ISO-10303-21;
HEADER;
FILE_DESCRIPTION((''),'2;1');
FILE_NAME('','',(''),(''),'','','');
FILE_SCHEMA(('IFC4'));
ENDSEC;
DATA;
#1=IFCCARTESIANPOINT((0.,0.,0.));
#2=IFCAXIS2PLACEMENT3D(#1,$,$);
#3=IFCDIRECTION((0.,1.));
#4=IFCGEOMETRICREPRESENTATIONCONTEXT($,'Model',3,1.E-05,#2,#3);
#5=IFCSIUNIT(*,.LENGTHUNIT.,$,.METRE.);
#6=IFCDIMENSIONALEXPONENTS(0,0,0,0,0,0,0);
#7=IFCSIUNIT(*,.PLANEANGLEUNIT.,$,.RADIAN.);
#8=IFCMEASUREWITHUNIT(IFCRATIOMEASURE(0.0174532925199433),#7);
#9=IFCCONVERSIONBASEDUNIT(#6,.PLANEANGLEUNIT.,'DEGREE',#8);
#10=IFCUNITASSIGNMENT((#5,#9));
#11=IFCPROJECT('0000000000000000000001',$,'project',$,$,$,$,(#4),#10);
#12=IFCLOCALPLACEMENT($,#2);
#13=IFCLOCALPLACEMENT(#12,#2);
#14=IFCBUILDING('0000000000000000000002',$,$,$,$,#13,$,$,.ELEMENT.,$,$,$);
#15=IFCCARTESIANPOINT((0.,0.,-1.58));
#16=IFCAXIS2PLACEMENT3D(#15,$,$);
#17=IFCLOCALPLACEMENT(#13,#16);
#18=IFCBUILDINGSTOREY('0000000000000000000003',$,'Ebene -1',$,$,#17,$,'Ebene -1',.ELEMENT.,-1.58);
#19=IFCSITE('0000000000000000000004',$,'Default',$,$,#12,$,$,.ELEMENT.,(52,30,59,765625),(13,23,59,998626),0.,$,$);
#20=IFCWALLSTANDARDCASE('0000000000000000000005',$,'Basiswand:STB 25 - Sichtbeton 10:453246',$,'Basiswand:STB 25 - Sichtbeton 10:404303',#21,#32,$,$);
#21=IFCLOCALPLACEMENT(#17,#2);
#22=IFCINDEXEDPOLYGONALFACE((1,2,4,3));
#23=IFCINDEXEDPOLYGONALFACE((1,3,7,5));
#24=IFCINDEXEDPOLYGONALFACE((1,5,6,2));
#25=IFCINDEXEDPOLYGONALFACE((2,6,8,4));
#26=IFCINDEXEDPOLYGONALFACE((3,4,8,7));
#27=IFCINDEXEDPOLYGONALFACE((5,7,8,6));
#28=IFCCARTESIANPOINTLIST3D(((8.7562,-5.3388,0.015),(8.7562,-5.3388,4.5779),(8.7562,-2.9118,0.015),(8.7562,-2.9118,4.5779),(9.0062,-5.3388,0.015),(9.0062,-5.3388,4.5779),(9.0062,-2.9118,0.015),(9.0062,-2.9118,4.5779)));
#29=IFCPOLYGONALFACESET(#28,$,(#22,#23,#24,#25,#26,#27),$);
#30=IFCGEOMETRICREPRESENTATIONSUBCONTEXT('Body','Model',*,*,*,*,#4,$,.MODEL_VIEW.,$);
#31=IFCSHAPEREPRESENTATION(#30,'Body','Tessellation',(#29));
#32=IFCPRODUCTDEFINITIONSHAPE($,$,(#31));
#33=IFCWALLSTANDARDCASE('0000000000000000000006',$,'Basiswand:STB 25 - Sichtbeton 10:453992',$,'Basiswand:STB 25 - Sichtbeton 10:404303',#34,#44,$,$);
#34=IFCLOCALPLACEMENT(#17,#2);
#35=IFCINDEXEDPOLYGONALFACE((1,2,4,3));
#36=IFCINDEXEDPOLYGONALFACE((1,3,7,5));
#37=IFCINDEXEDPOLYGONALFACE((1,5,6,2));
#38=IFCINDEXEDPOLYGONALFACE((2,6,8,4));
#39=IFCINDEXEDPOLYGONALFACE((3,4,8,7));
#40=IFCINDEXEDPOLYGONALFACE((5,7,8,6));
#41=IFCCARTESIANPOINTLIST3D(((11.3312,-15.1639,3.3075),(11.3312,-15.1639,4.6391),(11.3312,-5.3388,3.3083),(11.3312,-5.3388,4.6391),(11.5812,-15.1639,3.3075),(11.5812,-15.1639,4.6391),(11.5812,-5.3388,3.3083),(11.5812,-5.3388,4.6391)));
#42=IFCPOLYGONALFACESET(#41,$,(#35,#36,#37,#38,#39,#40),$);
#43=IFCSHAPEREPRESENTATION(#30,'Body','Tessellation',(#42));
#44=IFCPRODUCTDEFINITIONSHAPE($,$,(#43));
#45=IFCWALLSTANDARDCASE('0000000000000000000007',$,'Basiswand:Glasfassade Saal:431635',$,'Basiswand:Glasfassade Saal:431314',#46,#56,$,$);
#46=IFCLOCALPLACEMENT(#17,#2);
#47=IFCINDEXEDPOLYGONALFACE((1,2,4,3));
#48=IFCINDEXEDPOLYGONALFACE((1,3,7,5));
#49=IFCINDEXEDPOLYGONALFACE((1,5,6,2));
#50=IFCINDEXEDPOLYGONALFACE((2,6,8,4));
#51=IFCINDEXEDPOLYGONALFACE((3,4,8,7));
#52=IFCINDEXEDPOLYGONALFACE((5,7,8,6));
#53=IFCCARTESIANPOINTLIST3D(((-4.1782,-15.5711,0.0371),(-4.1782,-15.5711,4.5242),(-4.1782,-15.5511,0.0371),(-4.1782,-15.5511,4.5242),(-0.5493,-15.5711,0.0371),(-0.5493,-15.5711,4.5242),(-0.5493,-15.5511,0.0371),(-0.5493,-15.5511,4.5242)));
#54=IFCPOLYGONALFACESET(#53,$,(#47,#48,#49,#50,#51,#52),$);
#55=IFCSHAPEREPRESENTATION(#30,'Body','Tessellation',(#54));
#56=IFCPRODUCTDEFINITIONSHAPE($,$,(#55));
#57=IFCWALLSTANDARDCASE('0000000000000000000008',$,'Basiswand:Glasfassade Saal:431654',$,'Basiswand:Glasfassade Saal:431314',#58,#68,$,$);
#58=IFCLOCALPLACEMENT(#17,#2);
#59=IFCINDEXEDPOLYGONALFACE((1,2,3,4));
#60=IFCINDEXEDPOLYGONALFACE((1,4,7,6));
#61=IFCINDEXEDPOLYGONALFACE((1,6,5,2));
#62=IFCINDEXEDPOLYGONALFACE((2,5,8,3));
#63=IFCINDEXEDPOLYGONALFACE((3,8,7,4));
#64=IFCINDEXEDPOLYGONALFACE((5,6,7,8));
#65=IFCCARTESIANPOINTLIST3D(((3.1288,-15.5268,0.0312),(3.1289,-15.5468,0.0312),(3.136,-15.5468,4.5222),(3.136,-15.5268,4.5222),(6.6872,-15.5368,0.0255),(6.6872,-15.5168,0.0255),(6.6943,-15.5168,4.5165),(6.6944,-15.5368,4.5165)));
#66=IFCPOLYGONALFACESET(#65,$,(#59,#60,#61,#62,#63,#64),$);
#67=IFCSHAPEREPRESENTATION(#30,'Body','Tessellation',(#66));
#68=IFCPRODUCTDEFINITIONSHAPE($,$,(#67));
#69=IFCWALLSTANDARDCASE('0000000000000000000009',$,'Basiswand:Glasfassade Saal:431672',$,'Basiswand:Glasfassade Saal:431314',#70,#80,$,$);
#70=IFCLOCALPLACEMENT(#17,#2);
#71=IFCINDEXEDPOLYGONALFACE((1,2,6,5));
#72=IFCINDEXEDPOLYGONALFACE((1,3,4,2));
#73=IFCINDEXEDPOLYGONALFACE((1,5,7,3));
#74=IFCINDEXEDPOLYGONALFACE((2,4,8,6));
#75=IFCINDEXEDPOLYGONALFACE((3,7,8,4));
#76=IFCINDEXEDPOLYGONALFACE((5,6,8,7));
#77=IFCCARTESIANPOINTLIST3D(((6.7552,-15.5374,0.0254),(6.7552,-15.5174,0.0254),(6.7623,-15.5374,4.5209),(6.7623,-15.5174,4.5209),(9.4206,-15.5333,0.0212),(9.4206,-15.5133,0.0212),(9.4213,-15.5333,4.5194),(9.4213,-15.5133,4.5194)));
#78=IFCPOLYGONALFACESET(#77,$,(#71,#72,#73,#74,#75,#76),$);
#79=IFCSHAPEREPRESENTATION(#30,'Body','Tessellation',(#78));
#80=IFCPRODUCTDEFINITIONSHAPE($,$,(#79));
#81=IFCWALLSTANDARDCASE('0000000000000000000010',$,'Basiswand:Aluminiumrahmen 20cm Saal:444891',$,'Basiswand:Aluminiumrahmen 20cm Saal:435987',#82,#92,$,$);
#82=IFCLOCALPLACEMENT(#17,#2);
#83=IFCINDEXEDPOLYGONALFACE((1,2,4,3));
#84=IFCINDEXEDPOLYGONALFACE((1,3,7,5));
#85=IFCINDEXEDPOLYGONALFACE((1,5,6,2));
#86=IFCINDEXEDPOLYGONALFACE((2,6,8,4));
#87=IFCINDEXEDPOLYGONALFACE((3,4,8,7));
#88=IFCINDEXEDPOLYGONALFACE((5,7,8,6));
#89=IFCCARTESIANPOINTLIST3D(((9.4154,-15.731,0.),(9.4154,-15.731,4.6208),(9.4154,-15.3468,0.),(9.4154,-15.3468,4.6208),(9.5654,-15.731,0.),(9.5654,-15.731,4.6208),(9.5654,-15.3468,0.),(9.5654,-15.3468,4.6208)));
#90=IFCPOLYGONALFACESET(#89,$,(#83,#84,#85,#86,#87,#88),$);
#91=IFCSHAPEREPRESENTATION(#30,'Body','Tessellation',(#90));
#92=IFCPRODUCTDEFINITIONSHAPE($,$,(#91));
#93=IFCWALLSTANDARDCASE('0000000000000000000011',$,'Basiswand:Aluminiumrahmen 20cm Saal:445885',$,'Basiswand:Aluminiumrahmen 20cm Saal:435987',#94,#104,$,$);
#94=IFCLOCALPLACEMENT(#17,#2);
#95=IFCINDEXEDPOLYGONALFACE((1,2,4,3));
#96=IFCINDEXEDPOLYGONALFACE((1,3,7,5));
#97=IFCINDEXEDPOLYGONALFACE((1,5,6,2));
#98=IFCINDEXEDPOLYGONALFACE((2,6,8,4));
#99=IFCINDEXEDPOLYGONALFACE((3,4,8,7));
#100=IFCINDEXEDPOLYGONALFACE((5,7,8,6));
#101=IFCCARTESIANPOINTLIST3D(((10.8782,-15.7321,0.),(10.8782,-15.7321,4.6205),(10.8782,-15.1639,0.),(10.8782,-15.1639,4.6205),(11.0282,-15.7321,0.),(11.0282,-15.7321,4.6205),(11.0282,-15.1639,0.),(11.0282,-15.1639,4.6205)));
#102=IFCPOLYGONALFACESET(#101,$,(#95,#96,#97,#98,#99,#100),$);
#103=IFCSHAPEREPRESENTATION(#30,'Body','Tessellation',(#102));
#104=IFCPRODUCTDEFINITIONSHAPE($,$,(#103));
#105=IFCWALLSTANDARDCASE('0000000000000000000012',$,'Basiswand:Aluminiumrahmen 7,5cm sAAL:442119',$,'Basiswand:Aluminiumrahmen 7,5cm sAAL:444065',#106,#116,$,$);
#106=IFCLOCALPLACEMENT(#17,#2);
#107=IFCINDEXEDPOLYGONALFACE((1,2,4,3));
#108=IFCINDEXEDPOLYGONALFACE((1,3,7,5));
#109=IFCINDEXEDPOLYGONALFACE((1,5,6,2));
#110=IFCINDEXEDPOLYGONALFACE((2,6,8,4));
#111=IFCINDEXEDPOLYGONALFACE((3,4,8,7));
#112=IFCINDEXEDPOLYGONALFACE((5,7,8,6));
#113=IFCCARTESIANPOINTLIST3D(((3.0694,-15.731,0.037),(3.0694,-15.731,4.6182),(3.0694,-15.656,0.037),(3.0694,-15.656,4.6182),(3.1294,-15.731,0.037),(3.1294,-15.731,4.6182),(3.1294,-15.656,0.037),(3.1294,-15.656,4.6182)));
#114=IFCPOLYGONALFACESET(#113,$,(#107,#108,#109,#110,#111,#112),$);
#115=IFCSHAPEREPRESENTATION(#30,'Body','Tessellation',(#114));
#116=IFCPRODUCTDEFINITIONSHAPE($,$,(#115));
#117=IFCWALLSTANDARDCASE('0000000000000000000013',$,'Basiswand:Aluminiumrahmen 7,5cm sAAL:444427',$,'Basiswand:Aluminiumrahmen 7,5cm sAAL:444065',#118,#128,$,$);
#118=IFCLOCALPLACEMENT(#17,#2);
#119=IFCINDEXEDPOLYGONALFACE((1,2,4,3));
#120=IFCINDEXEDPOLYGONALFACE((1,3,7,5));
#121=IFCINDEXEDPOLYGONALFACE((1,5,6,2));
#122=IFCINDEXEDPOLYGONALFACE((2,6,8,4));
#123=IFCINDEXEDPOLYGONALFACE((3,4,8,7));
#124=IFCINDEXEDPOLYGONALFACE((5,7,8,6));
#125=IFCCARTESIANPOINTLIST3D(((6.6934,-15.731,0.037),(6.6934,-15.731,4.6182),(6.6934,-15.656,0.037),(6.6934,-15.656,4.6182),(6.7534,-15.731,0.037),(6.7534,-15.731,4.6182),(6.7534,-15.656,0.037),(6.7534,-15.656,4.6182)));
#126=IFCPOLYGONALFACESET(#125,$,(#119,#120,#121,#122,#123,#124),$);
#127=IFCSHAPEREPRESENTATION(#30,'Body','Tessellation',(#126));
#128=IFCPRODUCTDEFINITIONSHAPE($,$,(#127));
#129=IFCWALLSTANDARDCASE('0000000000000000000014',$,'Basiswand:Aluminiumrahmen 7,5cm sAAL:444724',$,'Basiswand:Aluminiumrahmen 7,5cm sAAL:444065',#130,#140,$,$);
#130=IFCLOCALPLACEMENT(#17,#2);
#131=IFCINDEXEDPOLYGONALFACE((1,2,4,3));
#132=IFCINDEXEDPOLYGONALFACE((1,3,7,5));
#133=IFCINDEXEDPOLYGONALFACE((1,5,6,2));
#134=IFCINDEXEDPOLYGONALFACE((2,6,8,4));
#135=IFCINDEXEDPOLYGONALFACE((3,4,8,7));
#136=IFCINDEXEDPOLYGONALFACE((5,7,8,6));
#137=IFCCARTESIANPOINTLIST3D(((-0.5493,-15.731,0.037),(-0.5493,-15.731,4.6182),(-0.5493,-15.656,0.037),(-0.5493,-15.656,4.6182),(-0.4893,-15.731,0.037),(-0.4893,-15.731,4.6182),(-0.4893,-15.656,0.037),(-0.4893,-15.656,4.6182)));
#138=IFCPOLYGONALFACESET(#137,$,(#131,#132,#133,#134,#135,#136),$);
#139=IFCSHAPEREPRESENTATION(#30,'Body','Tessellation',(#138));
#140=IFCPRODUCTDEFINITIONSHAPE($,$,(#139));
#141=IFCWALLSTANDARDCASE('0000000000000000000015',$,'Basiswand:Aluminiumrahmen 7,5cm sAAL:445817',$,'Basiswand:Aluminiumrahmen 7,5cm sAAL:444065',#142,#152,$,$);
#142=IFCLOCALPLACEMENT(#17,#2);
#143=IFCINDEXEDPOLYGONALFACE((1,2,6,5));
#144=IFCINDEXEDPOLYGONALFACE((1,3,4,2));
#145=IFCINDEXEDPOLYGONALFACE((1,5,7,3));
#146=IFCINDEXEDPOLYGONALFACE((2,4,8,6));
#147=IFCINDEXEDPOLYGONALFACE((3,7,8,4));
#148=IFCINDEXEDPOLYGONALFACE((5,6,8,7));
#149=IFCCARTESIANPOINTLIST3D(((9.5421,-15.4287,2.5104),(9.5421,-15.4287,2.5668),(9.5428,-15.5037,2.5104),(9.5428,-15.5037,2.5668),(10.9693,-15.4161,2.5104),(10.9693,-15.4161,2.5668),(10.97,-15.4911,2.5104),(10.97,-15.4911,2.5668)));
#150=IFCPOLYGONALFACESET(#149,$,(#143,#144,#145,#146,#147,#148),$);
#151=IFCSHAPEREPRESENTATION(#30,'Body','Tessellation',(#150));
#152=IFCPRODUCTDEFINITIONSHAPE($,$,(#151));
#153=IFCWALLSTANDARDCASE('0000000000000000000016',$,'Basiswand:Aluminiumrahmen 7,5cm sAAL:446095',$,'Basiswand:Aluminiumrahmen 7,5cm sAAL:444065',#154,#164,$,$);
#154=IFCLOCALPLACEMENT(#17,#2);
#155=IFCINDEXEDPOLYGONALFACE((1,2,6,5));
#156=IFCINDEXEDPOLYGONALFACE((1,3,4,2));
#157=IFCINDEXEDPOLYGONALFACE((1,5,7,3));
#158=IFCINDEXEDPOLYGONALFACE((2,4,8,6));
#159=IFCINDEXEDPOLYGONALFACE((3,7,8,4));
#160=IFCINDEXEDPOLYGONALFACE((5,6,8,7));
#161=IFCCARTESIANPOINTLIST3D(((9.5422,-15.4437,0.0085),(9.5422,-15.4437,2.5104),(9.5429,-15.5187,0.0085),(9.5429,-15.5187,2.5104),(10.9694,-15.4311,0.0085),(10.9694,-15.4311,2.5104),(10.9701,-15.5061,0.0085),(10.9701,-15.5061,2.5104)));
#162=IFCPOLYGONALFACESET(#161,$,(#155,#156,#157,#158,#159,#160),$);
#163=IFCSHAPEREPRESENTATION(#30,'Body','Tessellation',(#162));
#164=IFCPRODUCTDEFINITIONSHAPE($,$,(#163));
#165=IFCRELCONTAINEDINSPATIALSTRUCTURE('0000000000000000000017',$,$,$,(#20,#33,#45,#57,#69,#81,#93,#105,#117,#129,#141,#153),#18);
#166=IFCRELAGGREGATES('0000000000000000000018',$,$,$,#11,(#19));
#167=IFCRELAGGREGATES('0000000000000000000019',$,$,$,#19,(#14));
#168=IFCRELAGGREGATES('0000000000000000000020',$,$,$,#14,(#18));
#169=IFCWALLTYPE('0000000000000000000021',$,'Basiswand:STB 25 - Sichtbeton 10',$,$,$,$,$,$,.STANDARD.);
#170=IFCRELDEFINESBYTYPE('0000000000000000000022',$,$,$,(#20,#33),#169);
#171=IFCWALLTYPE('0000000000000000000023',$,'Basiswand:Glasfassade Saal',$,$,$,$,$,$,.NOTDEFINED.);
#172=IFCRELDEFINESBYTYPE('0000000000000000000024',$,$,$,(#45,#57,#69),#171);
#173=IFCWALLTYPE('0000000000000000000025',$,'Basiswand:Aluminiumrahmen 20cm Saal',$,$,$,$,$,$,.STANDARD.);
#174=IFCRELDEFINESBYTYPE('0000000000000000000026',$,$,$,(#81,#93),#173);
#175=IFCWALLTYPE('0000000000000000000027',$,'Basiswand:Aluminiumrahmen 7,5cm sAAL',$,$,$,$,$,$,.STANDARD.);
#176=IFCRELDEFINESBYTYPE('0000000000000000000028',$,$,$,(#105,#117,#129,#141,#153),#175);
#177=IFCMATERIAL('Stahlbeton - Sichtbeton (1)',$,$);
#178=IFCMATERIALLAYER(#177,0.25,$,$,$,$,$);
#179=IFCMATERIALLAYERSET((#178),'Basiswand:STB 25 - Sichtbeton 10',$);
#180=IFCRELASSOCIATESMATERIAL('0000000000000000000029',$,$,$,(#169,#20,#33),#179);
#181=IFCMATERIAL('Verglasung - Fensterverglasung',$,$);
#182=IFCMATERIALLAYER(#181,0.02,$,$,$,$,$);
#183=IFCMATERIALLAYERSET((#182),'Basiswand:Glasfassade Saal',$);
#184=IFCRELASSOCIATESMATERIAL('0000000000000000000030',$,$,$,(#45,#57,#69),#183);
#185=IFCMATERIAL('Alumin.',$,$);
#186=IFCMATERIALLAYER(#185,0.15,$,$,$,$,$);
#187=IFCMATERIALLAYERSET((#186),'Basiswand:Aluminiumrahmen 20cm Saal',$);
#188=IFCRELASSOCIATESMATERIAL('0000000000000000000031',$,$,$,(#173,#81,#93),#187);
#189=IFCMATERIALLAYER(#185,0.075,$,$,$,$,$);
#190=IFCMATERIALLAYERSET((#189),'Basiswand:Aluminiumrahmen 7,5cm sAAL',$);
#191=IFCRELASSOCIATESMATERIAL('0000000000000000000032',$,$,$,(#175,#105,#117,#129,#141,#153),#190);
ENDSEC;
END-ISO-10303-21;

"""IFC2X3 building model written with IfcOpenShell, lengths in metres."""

from ifc_helpers import new_model, entity, si_unit, converted_unit, direction, frame, frame_2d, origin, place, context, subcontext, project, spatial, rectangle, extrude, clip, halfspace, material, layer, layer_set, layer_usage, type_object, element, save


model = new_model("IFC2X3")

# Units and contexts
model_context = context("Model", 3, precision=1e-05, world=origin(), true_north=direction((0.0, 1.0)))
body_context = subcontext(model_context, "Body", "Model", "MODEL_VIEW")
ifc_project = project(units=[si_unit("LENGTHUNIT", "METRE"), converted_unit("PLANEANGLEUNIT", "DEGREE", entity("IfcRatioMeasure", 0.0174532925199433), si_unit("PLANEANGLEUNIT", "RADIAN"), dimensions=[0, 0, 0, 0, 0, 0, 0])], contexts=[model_context])

# Site, building, storey
site_placement = place(None, origin())
site = spatial("IfcSite", under=ifc_project, at=site_placement, Name="Default", CompositionType="ELEMENT", RefLatitude=(52, 30, 59, 765625), RefLongitude=(13, 23, 59, 998626), RefElevation=0.0)
building_placement = place(site_placement, origin())
building = spatial("IfcBuilding", under=site, at=building_placement, CompositionType="ELEMENT")
storey_placement = place(building_placement, frame((0.0, 0.0, -1.58)))
storey = spatial("IfcBuildingStorey", under=building, at=storey_placement, Name="Ebene -1", LongName="Ebene -1", CompositionType="ELEMENT", Elevation=-1.58)

# Shared definitions
ifc_material_1 = material(Name="Stahlbeton - Sichtbeton (1)")

# Walls
ifc_layer_1 = layer(ifc_material_1, 0.25)
ifc_layer_set_1 = layer_set([ifc_layer_1], Name="Basiswand:STB 25 - Sichtbeton 10")
ifc_layer_usage_1 = layer_usage(ifc_layer_set_1, "AXIS2", "NEGATIVE", 0.125)
wall_type_1 = type_object("IfcWallType", Name="Basiswand:STB 25 - Sichtbeton 10", PredefinedType="STANDARD", material=ifc_layer_set_1)
wall_1_placement = place(storey_placement, frame((8.8812, -5.3388, 0.015), z_axis=(0.0, 0.0, 1.0), x_axis=(0.0, 1.0, 0.0)))
element("IfcWallStandardCase", 1, at=wall_1_placement, inside=storey, type_object=wall_type_1, material=ifc_layer_usage_1, Name="Basiswand:STB 25 - Sichtbeton 10:453246", ObjectType="Basiswand:STB 25 - Sichtbeton 10:404303", context=body_context, shape_type="SweptSolid", body=[
    extrude(rectangle(XDim=2.427, YDim=0.25, at=frame_2d((1.2135, 0.0), x_axis=(-1.0, 0.0))), origin(), (0.0, 0.0, 1.0), 4.5629),
])
ifc_layer_usage_2 = layer_usage(ifc_layer_set_1, "AXIS2", "POSITIVE", -0.125)
wall_2_placement = place(storey_placement, frame((11.4562, -15.1639, 3.3075), z_axis=(0.0, 0.0, 1.0), x_axis=(0.0, 1.0, 0.0)))
element("IfcWallStandardCase", 2, at=wall_2_placement, inside=storey, type_object=wall_type_1, material=ifc_layer_usage_2, Name="Basiswand:STB 25 - Sichtbeton 10:453992", ObjectType="Basiswand:STB 25 - Sichtbeton 10:404303", context=body_context, shape_type="Clipping", body=[
    clip(extrude(rectangle(XDim=9.8251, YDim=0.25, at=frame_2d((4.9126, 0.0), x_axis=(-1.0, 0.0))), origin(), (0.0, 0.0, 1.0), 1.3316), halfspace(frame((9.8251, -0.125, 0.0008), z_axis=(0.000083, 0.0, -1.0), x_axis=(0.0, 1.0, 0.0)), False)),
])
ifc_material_2 = material(Name="Verglasung - Fensterverglasung")
ifc_layer_2 = layer(ifc_material_2, 0.02)
ifc_layer_set_2 = layer_set([ifc_layer_2], Name="Basiswand:Glasfassade Saal")
ifc_layer_usage_3 = layer_usage(ifc_layer_set_2, "AXIS2", "POSITIVE", -0.01)
wall_type_2 = type_object("IfcWallType", Name="Basiswand:Glasfassade Saal", PredefinedType="NOTDEFINED")
wall_3_placement = place(storey_placement, frame((-0.5493, -15.5611, 0.0371), z_axis=(0.0, 0.0, 1.0), x_axis=(-1.0, 0.0, 0.0)))
element("IfcWallStandardCase", 3, at=wall_3_placement, inside=storey, type_object=wall_type_2, material=ifc_layer_usage_3, Name="Basiswand:Glasfassade Saal:431635", ObjectType="Basiswand:Glasfassade Saal:431314", context=body_context, shape_type="SweptSolid", body=[
    extrude(rectangle(XDim=3.6289, YDim=0.02, at=frame_2d((1.8145, 0.0), x_axis=(-1.0, 0.0))), origin(), (0.0, 0.0, 1.0), 4.4871),
])
ifc_layer_usage_4 = layer_usage(ifc_layer_set_2, "AXIS2", "POSITIVE", -0.01)
wall_4_placement = place(storey_placement, frame((6.6944, -15.5268, 0.0255), z_axis=(0.0, 0.0, 1.0), x_axis=(-0.999996, -0.002817, 0.0)))
element("IfcWallStandardCase", 4, at=wall_4_placement, inside=storey, type_object=wall_type_2, material=ifc_layer_usage_4, Name="Basiswand:Glasfassade Saal:431654", ObjectType="Basiswand:Glasfassade Saal:431314", context=body_context, shape_type="Clipping", body=[
    clip(clip(clip(clip(extrude(rectangle(XDim=3.5655, YDim=0.02, at=frame_2d((1.7828, 0.0), x_axis=(-1.0, 0.0))), origin(), (0.0, 0.0, 1.0), 4.4966), halfspace(frame((0.0, -0.01, 4.4909), z_axis=(-0.001596, 0.0, 0.999999), x_axis=(0.0, 1.0, 0.0)), False)), halfspace(frame((0.0072, -0.01, 0.0), z_axis=(-0.999999, 0.0, -0.001596), x_axis=(0.0, 1.0, 0.0)), False)), halfspace(frame((3.5655, -0.01, 0.0057), z_axis=(0.001596, 0.0, -0.999999), x_axis=(0.0, 1.0, 0.0)), False)), halfspace(frame((3.5584, -0.01, 4.4966), z_axis=(0.999999, 0.0, 0.001596), x_axis=(0.0, 1.0, 0.0)), False)),
])
ifc_layer_usage_5 = layer_usage(ifc_layer_set_2, "AXIS2", "POSITIVE", -0.01)
wall_5_placement = place(storey_placement, frame((9.4213, -15.5233, 0.0212), z_axis=(0.0, 0.0, 1.0), x_axis=(-0.999999, -0.001547, 0.0)))
element("IfcWallStandardCase", 5, at=wall_5_placement, inside=storey, type_object=wall_type_2, material=ifc_layer_usage_5, Name="Basiswand:Glasfassade Saal:431672", ObjectType="Basiswand:Glasfassade Saal:431314", context=body_context, shape_type="Clipping", body=[
    clip(clip(clip(clip(extrude(rectangle(XDim=2.6661, YDim=0.02, at=frame_2d((1.333, 0.0), x_axis=(-1.0, 0.0))), origin(), (0.0, 0.0, 1.0), 4.4997), halfspace(frame((0.0, -0.01, 4.4982), z_axis=(-0.000583, 0.0, 1.0), x_axis=(0.0, 1.0, 0.0)), False)), halfspace(frame((0.0007, -0.01, 0.0), z_axis=(-1.0, 0.0, -0.000156), x_axis=(0.0, 1.0, 0.0)), False)), halfspace(frame((2.6661, -0.01, 0.0043), z_axis=(0.001596, 0.0, -0.999999), x_axis=(0.0, 1.0, 0.0)), False)), halfspace(frame((2.659, -0.01, 4.4997), z_axis=(0.999999, 0.0, 0.001573), x_axis=(0.0, 1.0, 0.0)), False)),
])
ifc_material_3 = material(Name="Alumin.")
ifc_layer_3 = layer(ifc_material_3, 0.15)
ifc_layer_set_3 = layer_set([ifc_layer_3], Name="Basiswand:Aluminiumrahmen 20cm Saal")
ifc_layer_usage_6 = layer_usage(ifc_layer_set_3, "AXIS2", "POSITIVE", -0.075)
wall_type_3 = type_object("IfcWallType", Name="Basiswand:Aluminiumrahmen 20cm Saal", PredefinedType="STANDARD", material=ifc_layer_set_3)
wall_6_placement = place(storey_placement, frame((9.4904, -15.731, 0.0), z_axis=(0.0, 0.0, 1.0), x_axis=(0.0, 1.0, 0.0)))
element("IfcWallStandardCase", 6, at=wall_6_placement, inside=storey, type_object=wall_type_3, material=ifc_layer_usage_6, Name="Basiswand:Aluminiumrahmen 20cm Saal:444891", ObjectType="Basiswand:Aluminiumrahmen 20cm Saal:435987", context=body_context, shape_type="SweptSolid", body=[
    extrude(rectangle(XDim=0.3842, YDim=0.15, at=frame_2d((0.1921, 0.0), x_axis=(-1.0, 0.0))), origin(), (0.0, 0.0, 1.0), 4.6208),
])
ifc_layer_usage_7 = layer_usage(ifc_layer_set_3, "AXIS2", "POSITIVE", -0.075)
wall_7_placement = place(storey_placement, frame((10.9532, -15.7321, 0.0), z_axis=(0.0, 0.0, 1.0), x_axis=(0.0, 1.0, 0.0)))
element("IfcWallStandardCase", 7, at=wall_7_placement, inside=storey, type_object=wall_type_3, material=ifc_layer_usage_7, Name="Basiswand:Aluminiumrahmen 20cm Saal:445885", ObjectType="Basiswand:Aluminiumrahmen 20cm Saal:435987", context=body_context, shape_type="SweptSolid", body=[
    extrude(rectangle(XDim=0.5682, YDim=0.15, at=frame_2d((0.2841, 0.0), x_axis=(-1.0, 0.0))), origin(), (0.0, 0.0, 1.0), 4.6205),
])
ifc_layer_4 = layer(ifc_material_3, 0.075)
ifc_layer_set_4 = layer_set([ifc_layer_4], Name="Basiswand:Aluminiumrahmen 7,5cm sAAL")
ifc_layer_usage_8 = layer_usage(ifc_layer_set_4, "AXIS2", "POSITIVE", -0.0375)
wall_type_4 = type_object("IfcWallType", Name="Basiswand:Aluminiumrahmen 7,5cm sAAL", PredefinedType="STANDARD", material=ifc_layer_set_4)
wall_8_placement = place(storey_placement, frame((3.0694, -15.6935, 0.037)))
element("IfcWallStandardCase", 8, at=wall_8_placement, inside=storey, type_object=wall_type_4, material=ifc_layer_usage_8, Name="Basiswand:Aluminiumrahmen 7,5cm sAAL:442119", ObjectType="Basiswand:Aluminiumrahmen 7,5cm sAAL:444065", context=body_context, shape_type="Clipping", body=[
    clip(clip(extrude(rectangle(XDim=0.06, YDim=0.075, at=frame_2d((0.03, 0.0), x_axis=(-1.0, 0.0))), origin(), (0.0, 0.0, 1.0), 4.5812), halfspace(frame((0.06, -0.0375, 0.0), z_axis=(-0.001583, 0.0, -0.999999), x_axis=(0.0, 1.0, 0.0)), False)), halfspace(frame((0.0, -0.0375, 4.5812), z_axis=(0.000336, 0.0, 1.0), x_axis=(0.0, 1.0, 0.0)), False)),
])
ifc_layer_usage_9 = layer_usage(ifc_layer_set_4, "AXIS2", "POSITIVE", -0.0375)
wall_9_placement = place(storey_placement, frame((6.6934, -15.6935, 0.037)))
element("IfcWallStandardCase", 9, at=wall_9_placement, inside=storey, type_object=wall_type_4, material=ifc_layer_usage_9, Name="Basiswand:Aluminiumrahmen 7,5cm sAAL:444427", ObjectType="Basiswand:Aluminiumrahmen 7,5cm sAAL:444065", context=body_context, shape_type="Clipping", body=[
    clip(clip(extrude(rectangle(XDim=0.06, YDim=0.075, at=frame_2d((0.03, 0.0), x_axis=(-1.0, 0.0))), origin(), (0.0, 0.0, 1.0), 4.5812), halfspace(frame((0.06, -0.0375, 0.0), z_axis=(-0.001583, 0.0, -0.999999), x_axis=(0.0, 1.0, 0.0)), False)), halfspace(frame((0.0, -0.0375, 4.5812), z_axis=(0.000336, 0.0, 1.0), x_axis=(0.0, 1.0, 0.0)), False)),
])
ifc_layer_usage_10 = layer_usage(ifc_layer_set_4, "AXIS2", "POSITIVE", -0.0375)
wall_10_placement = place(storey_placement, frame((-0.5493, -15.6935, 0.037)))
element("IfcWallStandardCase", 10, at=wall_10_placement, inside=storey, type_object=wall_type_4, material=ifc_layer_usage_10, Name="Basiswand:Aluminiumrahmen 7,5cm sAAL:444724", ObjectType="Basiswand:Aluminiumrahmen 7,5cm sAAL:444065", context=body_context, shape_type="Clipping", body=[
    clip(clip(extrude(rectangle(XDim=0.06, YDim=0.075, at=frame_2d((0.03, 0.0), x_axis=(-1.0, 0.0))), origin(), (0.0, 0.0, 1.0), 4.5812), halfspace(frame((0.06, -0.0375, 0.0), z_axis=(-0.001583, 0.0, -0.999999), x_axis=(0.0, 1.0, 0.0)), False)), halfspace(frame((0.0, -0.0375, 4.5812), z_axis=(0.000336, 0.0, 1.0), x_axis=(0.0, 1.0, 0.0)), False)),
])
ifc_layer_usage_11 = layer_usage(ifc_layer_set_4, "AXIS2", "POSITIVE", -0.0375)
wall_11_placement = place(storey_placement, frame((10.9696, -15.4536, 2.5104), z_axis=(0.0, 0.0, 1.0), x_axis=(-0.999961, -0.008874, 0.0)))
element("IfcWallStandardCase", 11, at=wall_11_placement, inside=storey, type_object=wall_type_4, material=ifc_layer_usage_11, Name="Basiswand:Aluminiumrahmen 7,5cm sAAL:445817", ObjectType="Basiswand:Aluminiumrahmen 7,5cm sAAL:444065", context=body_context, shape_type="Clipping", body=[
    clip(clip(extrude(rectangle(XDim=1.4273, YDim=0.075, at=frame_2d((0.7136, 0.0), x_axis=(-1.0, 0.0))), origin(), (0.0, 0.0, 1.0), 0.0564), halfspace(frame((0.0, -0.0375, 0.0564), z_axis=(0.0, 0.0, 1.0), x_axis=(0.0, 1.0, 0.0)), False)), halfspace(frame((1.4273, -0.0375, 0.0), z_axis=(0.0, 0.0, -1.0), x_axis=(0.0, 1.0, 0.0)), False)),
])
ifc_layer_usage_12 = layer_usage(ifc_layer_set_4, "AXIS2", "POSITIVE", -0.0375)
wall_12_placement = place(storey_placement, frame((9.5426, -15.4812, 0.0085), z_axis=(0.0, 0.0, 1.0), x_axis=(0.999961, 0.008874, 0.0)))
element("IfcWallStandardCase", 12, at=wall_12_placement, inside=storey, type_object=wall_type_4, material=ifc_layer_usage_12, Name="Basiswand:Aluminiumrahmen 7,5cm sAAL:446095", ObjectType="Basiswand:Aluminiumrahmen 7,5cm sAAL:444065", context=body_context, shape_type="Clipping", body=[
    clip(clip(extrude(rectangle(XDim=1.4273, YDim=0.075, at=frame_2d((0.7136, 0.0), x_axis=(-1.0, 0.0))), origin(), (0.0, 0.0, 1.0), 2.5018), halfspace(frame((1.4273, -0.0375, 0.0), z_axis=(-0.000002, 0.0, -1.0), x_axis=(0.0, 1.0, 0.0)), False)), halfspace(frame((0.0, -0.0375, 2.5018), z_axis=(0.0, 0.0, 1.0), x_axis=(0.0, 1.0, 0.0)), False)),
])

save(model, "model.ifc")
